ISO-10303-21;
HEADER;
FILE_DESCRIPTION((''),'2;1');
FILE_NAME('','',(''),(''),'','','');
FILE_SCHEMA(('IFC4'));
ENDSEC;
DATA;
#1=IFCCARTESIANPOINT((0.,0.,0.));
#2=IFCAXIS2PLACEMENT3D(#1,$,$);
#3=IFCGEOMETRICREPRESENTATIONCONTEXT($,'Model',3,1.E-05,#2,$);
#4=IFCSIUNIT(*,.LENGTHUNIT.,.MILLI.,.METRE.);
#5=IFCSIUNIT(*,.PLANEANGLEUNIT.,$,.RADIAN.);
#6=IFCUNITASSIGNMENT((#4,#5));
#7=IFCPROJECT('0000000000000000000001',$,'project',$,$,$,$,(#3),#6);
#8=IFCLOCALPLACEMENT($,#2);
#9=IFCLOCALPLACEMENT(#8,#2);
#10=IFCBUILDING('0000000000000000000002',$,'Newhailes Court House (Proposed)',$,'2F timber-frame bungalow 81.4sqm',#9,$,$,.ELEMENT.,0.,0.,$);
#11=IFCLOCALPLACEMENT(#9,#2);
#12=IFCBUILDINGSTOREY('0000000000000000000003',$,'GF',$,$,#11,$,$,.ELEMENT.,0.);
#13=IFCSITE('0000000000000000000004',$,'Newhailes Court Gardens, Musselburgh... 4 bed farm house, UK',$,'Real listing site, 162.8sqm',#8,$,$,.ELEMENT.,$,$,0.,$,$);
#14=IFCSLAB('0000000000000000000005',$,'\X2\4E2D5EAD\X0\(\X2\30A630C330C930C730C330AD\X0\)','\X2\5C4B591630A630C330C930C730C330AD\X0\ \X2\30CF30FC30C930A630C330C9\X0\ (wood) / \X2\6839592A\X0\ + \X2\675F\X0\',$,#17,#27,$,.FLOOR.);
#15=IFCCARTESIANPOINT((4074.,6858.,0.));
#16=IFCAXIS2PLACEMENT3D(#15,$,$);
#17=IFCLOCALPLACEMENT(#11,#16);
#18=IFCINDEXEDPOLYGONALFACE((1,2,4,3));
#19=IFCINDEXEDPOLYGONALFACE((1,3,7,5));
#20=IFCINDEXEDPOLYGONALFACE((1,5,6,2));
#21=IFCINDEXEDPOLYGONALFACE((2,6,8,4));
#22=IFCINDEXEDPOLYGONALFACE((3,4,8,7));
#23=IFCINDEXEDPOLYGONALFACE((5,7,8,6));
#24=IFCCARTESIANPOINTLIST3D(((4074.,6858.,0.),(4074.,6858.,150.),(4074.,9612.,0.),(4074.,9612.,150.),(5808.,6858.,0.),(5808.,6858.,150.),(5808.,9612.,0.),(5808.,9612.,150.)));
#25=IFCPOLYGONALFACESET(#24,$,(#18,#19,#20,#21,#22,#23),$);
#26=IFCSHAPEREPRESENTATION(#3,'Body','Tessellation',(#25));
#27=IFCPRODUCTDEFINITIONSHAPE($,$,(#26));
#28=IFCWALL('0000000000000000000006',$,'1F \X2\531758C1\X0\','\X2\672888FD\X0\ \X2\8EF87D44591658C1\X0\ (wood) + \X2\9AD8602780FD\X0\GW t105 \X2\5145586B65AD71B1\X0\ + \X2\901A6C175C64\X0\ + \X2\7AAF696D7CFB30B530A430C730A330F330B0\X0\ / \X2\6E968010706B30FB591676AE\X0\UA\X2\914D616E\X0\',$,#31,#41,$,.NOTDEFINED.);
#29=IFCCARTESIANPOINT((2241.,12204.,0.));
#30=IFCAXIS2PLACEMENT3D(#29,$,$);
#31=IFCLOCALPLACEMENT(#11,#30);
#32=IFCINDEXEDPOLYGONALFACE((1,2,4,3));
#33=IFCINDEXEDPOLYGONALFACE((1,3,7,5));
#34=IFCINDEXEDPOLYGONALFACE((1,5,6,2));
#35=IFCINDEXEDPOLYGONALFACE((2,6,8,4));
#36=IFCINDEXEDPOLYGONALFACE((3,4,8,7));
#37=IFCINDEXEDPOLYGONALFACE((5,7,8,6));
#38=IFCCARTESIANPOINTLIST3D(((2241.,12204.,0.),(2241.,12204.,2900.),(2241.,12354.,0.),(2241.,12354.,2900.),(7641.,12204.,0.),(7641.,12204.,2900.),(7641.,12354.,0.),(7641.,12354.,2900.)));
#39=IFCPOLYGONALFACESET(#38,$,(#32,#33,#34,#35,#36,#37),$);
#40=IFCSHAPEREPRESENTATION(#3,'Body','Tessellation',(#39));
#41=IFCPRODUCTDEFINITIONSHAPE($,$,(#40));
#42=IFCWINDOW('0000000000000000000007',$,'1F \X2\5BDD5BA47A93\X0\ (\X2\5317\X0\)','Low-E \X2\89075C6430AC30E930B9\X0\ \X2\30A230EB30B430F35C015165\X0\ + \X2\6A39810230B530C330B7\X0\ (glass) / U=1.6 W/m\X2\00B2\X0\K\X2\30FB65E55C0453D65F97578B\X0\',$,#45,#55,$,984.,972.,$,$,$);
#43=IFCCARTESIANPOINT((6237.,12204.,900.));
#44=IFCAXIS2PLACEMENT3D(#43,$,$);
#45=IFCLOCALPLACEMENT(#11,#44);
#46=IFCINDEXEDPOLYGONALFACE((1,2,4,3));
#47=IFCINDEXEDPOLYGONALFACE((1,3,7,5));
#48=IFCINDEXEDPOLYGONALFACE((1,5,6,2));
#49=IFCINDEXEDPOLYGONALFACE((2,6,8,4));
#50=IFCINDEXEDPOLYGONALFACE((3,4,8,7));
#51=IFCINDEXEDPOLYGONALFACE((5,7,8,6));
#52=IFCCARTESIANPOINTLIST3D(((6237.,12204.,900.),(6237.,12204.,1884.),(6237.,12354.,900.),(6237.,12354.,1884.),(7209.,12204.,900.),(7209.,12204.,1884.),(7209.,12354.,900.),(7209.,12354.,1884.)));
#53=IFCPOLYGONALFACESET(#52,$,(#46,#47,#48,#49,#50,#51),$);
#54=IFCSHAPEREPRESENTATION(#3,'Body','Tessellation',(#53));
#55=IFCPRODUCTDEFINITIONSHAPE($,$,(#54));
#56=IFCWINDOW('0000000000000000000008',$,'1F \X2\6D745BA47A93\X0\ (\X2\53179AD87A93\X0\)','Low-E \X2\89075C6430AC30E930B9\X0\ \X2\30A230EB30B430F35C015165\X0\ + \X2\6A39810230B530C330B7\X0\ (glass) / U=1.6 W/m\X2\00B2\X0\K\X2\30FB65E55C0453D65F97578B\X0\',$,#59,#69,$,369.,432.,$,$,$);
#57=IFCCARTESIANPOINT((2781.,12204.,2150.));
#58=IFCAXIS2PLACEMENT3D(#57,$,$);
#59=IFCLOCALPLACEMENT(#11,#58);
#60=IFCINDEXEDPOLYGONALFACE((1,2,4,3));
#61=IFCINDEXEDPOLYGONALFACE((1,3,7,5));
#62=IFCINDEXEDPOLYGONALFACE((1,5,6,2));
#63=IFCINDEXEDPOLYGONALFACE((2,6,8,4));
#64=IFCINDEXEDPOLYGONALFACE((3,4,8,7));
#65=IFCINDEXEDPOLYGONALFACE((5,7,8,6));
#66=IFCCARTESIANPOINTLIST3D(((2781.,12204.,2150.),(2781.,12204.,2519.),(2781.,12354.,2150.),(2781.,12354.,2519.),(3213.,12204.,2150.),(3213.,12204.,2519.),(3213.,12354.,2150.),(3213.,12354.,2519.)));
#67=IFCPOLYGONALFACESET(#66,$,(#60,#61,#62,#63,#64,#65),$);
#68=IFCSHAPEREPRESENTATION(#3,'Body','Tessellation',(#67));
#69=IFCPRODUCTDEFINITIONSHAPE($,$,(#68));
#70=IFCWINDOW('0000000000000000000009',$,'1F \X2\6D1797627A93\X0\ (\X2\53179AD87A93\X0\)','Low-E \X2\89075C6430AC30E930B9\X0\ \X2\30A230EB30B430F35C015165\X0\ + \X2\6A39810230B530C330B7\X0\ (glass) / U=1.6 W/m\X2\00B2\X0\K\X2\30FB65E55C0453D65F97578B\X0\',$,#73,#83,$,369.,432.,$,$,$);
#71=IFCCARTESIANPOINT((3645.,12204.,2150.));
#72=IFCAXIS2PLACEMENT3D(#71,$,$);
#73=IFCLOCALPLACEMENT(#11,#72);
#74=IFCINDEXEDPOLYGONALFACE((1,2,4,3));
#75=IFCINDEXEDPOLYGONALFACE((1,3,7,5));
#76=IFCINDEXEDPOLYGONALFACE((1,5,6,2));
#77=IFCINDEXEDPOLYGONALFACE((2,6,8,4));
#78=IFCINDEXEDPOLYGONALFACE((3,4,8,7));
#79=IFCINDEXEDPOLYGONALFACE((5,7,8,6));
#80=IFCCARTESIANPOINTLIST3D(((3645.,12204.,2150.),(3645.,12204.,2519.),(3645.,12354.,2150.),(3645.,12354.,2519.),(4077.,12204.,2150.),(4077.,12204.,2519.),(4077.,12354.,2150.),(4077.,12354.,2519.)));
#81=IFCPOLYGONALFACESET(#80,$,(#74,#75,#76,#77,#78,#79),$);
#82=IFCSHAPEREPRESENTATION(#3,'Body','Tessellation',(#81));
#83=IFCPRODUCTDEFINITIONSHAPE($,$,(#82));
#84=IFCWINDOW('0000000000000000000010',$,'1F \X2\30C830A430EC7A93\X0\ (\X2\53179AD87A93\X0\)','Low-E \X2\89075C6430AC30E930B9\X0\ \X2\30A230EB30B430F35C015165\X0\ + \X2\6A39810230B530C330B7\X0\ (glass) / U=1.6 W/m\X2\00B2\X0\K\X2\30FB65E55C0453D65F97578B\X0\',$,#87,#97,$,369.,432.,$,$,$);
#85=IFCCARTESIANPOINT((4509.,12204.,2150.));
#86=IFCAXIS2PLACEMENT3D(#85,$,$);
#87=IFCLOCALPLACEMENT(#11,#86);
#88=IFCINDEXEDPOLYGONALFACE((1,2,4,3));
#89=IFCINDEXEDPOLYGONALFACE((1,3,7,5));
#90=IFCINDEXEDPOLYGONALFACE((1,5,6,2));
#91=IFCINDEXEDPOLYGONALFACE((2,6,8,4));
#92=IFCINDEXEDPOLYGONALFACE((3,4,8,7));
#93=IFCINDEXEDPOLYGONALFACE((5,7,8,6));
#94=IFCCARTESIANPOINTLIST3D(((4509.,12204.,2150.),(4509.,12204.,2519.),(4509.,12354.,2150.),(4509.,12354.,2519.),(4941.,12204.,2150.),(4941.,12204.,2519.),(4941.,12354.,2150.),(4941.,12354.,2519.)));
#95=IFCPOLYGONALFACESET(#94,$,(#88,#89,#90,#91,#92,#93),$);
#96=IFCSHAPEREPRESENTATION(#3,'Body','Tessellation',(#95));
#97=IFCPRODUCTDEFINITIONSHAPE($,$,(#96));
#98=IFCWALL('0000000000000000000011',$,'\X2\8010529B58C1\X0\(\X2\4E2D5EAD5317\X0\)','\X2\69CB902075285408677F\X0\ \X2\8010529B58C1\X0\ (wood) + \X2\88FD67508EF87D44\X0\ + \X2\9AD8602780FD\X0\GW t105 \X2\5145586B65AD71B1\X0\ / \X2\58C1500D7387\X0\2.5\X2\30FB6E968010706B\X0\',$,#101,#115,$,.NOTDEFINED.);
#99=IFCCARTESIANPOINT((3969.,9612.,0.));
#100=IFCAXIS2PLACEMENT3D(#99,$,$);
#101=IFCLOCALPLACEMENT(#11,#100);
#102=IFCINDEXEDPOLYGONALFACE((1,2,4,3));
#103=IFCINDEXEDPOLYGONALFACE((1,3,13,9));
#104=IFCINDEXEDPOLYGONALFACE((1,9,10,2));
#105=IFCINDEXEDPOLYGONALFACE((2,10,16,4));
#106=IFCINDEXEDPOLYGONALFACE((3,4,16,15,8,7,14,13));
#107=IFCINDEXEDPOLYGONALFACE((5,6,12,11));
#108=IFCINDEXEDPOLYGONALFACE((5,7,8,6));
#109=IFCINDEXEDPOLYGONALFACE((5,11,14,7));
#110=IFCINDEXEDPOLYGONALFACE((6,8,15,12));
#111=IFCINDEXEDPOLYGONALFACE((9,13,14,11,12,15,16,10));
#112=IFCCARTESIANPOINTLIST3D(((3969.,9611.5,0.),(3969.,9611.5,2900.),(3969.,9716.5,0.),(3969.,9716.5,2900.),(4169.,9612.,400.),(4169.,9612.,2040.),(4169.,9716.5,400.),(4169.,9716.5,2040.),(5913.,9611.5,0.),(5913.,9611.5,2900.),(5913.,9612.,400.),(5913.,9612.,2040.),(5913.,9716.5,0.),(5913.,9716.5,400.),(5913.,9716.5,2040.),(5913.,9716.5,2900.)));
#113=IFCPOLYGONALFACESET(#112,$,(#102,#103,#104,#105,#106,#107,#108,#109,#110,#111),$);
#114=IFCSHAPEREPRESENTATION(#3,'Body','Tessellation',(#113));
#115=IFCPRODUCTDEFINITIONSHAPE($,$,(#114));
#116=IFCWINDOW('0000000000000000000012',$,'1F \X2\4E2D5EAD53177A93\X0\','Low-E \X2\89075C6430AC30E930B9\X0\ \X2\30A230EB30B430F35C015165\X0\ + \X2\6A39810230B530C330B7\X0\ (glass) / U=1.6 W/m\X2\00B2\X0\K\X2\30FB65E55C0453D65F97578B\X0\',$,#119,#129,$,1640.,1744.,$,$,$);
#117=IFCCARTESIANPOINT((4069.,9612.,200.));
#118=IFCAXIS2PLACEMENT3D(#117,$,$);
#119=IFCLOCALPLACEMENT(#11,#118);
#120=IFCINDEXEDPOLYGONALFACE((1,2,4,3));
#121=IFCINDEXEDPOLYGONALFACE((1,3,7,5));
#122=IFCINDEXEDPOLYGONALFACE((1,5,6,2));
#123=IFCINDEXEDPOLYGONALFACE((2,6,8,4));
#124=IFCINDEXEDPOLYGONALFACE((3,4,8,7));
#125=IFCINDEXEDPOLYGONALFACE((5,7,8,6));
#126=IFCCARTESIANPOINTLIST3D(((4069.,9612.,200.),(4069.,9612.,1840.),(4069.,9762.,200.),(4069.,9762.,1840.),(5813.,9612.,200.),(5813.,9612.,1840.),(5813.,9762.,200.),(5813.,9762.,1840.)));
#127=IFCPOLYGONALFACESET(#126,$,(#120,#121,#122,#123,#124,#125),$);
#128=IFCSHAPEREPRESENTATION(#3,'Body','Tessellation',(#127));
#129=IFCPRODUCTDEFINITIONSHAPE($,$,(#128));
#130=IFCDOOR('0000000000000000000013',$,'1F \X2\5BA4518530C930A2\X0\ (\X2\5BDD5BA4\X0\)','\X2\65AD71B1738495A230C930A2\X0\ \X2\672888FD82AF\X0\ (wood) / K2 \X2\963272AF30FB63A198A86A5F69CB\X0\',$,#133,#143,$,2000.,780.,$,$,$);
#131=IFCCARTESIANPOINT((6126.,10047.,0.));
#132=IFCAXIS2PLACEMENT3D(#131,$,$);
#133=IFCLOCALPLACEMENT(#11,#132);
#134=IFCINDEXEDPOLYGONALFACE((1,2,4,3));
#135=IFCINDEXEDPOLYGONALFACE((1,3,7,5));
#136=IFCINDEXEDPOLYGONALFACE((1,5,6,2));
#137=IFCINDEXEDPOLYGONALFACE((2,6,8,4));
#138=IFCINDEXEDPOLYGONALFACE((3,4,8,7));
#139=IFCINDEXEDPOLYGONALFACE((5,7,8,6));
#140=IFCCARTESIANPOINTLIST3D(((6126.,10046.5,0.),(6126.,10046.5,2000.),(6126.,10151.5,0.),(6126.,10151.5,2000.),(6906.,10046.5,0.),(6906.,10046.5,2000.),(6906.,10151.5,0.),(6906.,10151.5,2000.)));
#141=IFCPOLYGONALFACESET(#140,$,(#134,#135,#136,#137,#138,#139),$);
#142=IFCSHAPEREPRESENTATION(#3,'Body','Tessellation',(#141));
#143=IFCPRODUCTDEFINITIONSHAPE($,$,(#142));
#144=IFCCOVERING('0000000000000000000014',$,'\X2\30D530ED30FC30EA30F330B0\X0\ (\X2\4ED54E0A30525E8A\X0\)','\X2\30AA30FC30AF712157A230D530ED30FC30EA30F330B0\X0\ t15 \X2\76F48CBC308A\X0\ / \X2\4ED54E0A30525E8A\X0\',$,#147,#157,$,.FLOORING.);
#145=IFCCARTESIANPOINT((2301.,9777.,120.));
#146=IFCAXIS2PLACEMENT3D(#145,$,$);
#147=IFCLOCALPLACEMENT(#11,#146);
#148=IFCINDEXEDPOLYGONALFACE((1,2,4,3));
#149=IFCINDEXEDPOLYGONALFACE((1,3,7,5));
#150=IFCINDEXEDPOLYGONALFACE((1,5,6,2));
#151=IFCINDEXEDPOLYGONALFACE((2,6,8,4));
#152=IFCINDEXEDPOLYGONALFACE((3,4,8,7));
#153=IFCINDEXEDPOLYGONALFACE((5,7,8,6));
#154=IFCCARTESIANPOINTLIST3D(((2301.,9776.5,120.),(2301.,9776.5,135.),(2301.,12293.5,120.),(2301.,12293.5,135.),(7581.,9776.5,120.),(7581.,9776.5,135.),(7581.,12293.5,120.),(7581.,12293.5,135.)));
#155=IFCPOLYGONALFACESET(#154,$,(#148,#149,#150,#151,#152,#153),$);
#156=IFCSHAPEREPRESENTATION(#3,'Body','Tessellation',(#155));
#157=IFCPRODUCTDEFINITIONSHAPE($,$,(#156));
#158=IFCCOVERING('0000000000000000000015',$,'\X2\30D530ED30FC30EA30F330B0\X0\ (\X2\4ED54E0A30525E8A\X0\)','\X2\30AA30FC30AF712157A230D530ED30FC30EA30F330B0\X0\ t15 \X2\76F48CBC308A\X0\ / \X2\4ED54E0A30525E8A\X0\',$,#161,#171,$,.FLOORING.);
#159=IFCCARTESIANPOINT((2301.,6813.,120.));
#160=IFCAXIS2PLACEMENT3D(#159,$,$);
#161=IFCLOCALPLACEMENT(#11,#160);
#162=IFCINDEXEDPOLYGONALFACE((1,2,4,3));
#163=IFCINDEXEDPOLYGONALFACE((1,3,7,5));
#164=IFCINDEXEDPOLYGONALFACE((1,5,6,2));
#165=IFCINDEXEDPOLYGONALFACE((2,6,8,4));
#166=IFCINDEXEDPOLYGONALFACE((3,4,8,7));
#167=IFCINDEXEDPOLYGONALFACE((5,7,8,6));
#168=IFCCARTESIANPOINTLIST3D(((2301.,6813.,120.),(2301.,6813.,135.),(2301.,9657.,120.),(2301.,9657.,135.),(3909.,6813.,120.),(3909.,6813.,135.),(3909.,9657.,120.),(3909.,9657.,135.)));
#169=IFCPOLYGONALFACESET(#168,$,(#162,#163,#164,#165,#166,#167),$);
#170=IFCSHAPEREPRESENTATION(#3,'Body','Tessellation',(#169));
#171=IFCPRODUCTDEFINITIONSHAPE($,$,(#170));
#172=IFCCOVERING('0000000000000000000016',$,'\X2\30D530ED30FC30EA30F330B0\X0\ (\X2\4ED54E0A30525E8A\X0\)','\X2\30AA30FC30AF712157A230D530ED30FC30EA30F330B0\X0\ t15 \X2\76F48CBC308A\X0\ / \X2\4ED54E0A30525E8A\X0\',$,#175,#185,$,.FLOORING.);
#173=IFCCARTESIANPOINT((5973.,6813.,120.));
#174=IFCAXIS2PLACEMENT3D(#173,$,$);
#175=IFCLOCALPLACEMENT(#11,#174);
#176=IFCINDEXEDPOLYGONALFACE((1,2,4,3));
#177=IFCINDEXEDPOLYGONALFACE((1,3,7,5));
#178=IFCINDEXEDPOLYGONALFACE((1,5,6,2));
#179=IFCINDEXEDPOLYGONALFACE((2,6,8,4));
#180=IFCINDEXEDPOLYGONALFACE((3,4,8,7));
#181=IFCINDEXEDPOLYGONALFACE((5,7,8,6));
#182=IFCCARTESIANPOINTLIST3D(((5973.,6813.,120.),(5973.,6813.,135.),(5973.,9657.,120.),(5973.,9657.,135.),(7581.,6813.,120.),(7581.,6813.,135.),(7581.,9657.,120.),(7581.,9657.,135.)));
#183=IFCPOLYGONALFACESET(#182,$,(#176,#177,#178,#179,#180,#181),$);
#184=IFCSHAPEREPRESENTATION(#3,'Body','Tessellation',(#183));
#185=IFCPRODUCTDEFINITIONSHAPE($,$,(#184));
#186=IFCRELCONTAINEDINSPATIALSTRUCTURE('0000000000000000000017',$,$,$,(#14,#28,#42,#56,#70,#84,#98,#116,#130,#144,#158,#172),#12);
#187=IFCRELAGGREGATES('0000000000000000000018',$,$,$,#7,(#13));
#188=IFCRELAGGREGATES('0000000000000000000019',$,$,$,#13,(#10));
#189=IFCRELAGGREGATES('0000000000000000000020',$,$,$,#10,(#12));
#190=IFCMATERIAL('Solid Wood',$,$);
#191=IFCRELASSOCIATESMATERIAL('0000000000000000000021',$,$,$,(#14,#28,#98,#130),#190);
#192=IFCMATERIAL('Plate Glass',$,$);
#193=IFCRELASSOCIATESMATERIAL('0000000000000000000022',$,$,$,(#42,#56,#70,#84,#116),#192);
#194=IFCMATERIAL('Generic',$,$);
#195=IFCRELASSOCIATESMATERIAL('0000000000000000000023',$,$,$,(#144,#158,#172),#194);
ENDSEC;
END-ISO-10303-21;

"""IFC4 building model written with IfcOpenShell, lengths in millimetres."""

from ifc_helpers import new_model, si_unit, frame, frame_2d, origin, place, context, project, spatial, rectangle, extrude, material, element, fill, save


model = new_model("IFC4")

# Units and contexts
model_context = context("Model", 3, precision=1e-05, world=origin())
ifc_project = project(units=[si_unit("LENGTHUNIT", "METRE", prefix="MILLI"), si_unit("PLANEANGLEUNIT", "RADIAN")], contexts=[model_context])

# Site, building, storey
site_placement = place(None, origin())
site = spatial("IfcSite", under=ifc_project, at=site_placement, Name="Newhailes Court Gardens, Musselburgh... 4 bed farm house, UK", ObjectType="Real listing site, 162.8sqm", CompositionType="ELEMENT", RefElevation=0.0)
building_placement = place(site_placement, origin())
building = spatial("IfcBuilding", under=site, at=building_placement, Name="Newhailes Court House (Proposed)", ObjectType="2F timber-frame bungalow 81.4sqm", CompositionType="ELEMENT", ElevationOfRefHeight=0.0, ElevationOfTerrain=0.0)
storey_placement = place(building_placement, origin())
storey = spatial("IfcBuildingStorey", under=building, at=storey_placement, Name="GF", CompositionType="ELEMENT", Elevation=0.0)

# Slab
ifc_material_1 = material(Name="Solid Wood")
slab_1_placement = place(storey_placement, frame((4074.0, 6858.0, 0.0)))
element("IfcSlab", 1, at=slab_1_placement, inside=storey, material=ifc_material_1, Name="中庭(ウッドデッキ)", Description="屋外ウッドデッキ ハードウッド (wood) / 根太 + 束", PredefinedType="FLOOR", context=model_context, shape_type="SweptSolid", body=[
    extrude(rectangle(XDim=1734.0, YDim=2754.0, at=frame_2d((867.0, 1377.0))), frame((4074.0, 6858.0, 0.0)), (0.0, 0.0, 1.0), 150.0),
])

# Wall, openings, windows
wall_1_placement = place(storey_placement, frame((2241.0, 12204.0, 0.0)))
wall_1 = element("IfcWall", 2, at=wall_1_placement, inside=storey, material=ifc_material_1, Name="1F 北壁", Description="木製 軸組外壁 (wood) + 高性能GW t105 充填断熱 + 通気層 + 窯業系サイディング / 準耐火・外皮UA配慮", PredefinedType="NOTDEFINED", context=model_context, shape_type="SweptSolid", body=[
    extrude(rectangle(XDim=5400.0, YDim=150.0, at=frame_2d((2700.0, 75.0))), frame((2241.0, 12204.0, 0.0)), (0.0, 0.0, 1.0), 2900.0),
])
opening_1_placement = place(storey_placement, frame((6237.0, 12204.0, 900.0)))
opening_1 = element("IfcOpeningElement", 3, at=opening_1_placement, cuts=wall_1, PredefinedType="NOTDEFINED", context=model_context, shape_type="SweptSolid", body=[
    extrude(rectangle(XDim=972.0, YDim=150.0, at=frame_2d((486.0, 75.0))), frame((6237.0, 12204.0, 900.0)), (0.0, 0.0, 1.0), 984.0),
])
opening_2_placement = place(storey_placement, frame((2781.0, 12204.0, 2150.0)))
opening_2 = element("IfcOpeningElement", 4, at=opening_2_placement, cuts=wall_1, PredefinedType="NOTDEFINED", context=model_context, shape_type="SweptSolid", body=[
    extrude(rectangle(XDim=432.0, YDim=150.0, at=frame_2d((216.0, 75.0))), frame((2781.0, 12204.0, 2150.0)), (0.0, 0.0, 1.0), 369.0),
])
opening_3_placement = place(storey_placement, frame((3645.0, 12204.0, 2150.0)))
opening_3 = element("IfcOpeningElement", 5, at=opening_3_placement, cuts=wall_1, PredefinedType="NOTDEFINED", context=model_context, shape_type="SweptSolid", body=[
    extrude(rectangle(XDim=432.0, YDim=150.0, at=frame_2d((216.0, 75.0))), frame((3645.0, 12204.0, 2150.0)), (0.0, 0.0, 1.0), 369.0),
])
opening_4_placement = place(storey_placement, frame((4509.0, 12204.0, 2150.0)))
opening_4 = element("IfcOpeningElement", 6, at=opening_4_placement, cuts=wall_1, PredefinedType="NOTDEFINED", context=model_context, shape_type="SweptSolid", body=[
    extrude(rectangle(XDim=432.0, YDim=150.0, at=frame_2d((216.0, 75.0))), frame((4509.0, 12204.0, 2150.0)), (0.0, 0.0, 1.0), 369.0),
])
ifc_material_2 = material(Name="Plate Glass")
window_1_placement = place(storey_placement, frame((6237.0, 12204.0, 900.0)))
window_1 = element("IfcWindow", 7, at=window_1_placement, inside=storey, material=ifc_material_2, Name="1F 寝室窓 (北)", Description="Low-E 複層ガラス アルゴン封入 + 樹脂サッシ (glass) / U=1.6 W/m²K・日射取得型", OverallHeight=984.0, OverallWidth=972.0, context=model_context, shape_type="SweptSolid", body=[
    extrude(rectangle(XDim=972.0, YDim=150.0, at=frame_2d((486.0, 75.0))), frame((6237.0, 12204.0, 900.0)), (0.0, 0.0, 1.0), 984.0),
])
fill(opening_1, window_1)
window_2_placement = place(storey_placement, frame((2781.0, 12204.0, 2150.0)))
window_2 = element("IfcWindow", 8, at=window_2_placement, inside=storey, material=ifc_material_2, Name="1F 浴室窓 (北高窓)", Description="Low-E 複層ガラス アルゴン封入 + 樹脂サッシ (glass) / U=1.6 W/m²K・日射取得型", OverallHeight=369.0, OverallWidth=432.0, context=model_context, shape_type="SweptSolid", body=[
    extrude(rectangle(XDim=432.0, YDim=150.0, at=frame_2d((216.0, 75.0))), frame((2781.0, 12204.0, 2150.0)), (0.0, 0.0, 1.0), 369.0),
])
fill(opening_2, window_2)
window_3_placement = place(storey_placement, frame((3645.0, 12204.0, 2150.0)))
window_3 = element("IfcWindow", 9, at=window_3_placement, inside=storey, material=ifc_material_2, Name="1F 洗面窓 (北高窓)", Description="Low-E 複層ガラス アルゴン封入 + 樹脂サッシ (glass) / U=1.6 W/m²K・日射取得型", OverallHeight=369.0, OverallWidth=432.0, context=model_context, shape_type="SweptSolid", body=[
    extrude(rectangle(XDim=432.0, YDim=150.0, at=frame_2d((216.0, 75.0))), frame((3645.0, 12204.0, 2150.0)), (0.0, 0.0, 1.0), 369.0),
])
fill(opening_3, window_3)
window_4_placement = place(storey_placement, frame((4509.0, 12204.0, 2150.0)))
window_4 = element("IfcWindow", 10, at=window_4_placement, inside=storey, material=ifc_material_2, Name="1F トイレ窓 (北高窓)", Description="Low-E 複層ガラス アルゴン封入 + 樹脂サッシ (glass) / U=1.6 W/m²K・日射取得型", OverallHeight=369.0, OverallWidth=432.0, context=model_context, shape_type="SweptSolid", body=[
    extrude(rectangle(XDim=432.0, YDim=150.0, at=frame_2d((216.0, 75.0))), frame((4509.0, 12204.0, 2150.0)), (0.0, 0.0, 1.0), 369.0),
])
fill(opening_4, window_4)

# Wall, opening, window
wall_2_placement = place(storey_placement, frame((3969.0, 9612.0, 0.0)))
wall_2 = element("IfcWall", 11, at=wall_2_placement, inside=storey, material=ifc_material_1, Name="耐力壁(中庭北)", Description="構造用合板 耐力壁 (wood) + 製材軸組 + 高性能GW t105 充填断熱 / 壁倍率2.5・準耐火", PredefinedType="NOTDEFINED", context=model_context, shape_type="SweptSolid", body=[
    extrude(rectangle(XDim=1944.0, YDim=105.0, at=frame_2d((972.0, 52.0))), frame((3969.0, 9612.0, 0.0)), (0.0, 0.0, 1.0), 2900.0),
])
opening_5_placement = place(storey_placement, frame((4069.0, 9612.0, 200.0)))
opening_5 = element("IfcOpeningElement", 12, at=opening_5_placement, cuts=wall_2, PredefinedType="NOTDEFINED", context=model_context, shape_type="SweptSolid", body=[
    extrude(rectangle(XDim=1744.0, YDim=150.0, at=frame_2d((872.0, 75.0))), frame((4069.0, 9612.0, 200.0)), (0.0, 0.0, 1.0), 1640.0),
])
window_5_placement = place(storey_placement, frame((4069.0, 9612.0, 200.0)))
window_5 = element("IfcWindow", 13, at=window_5_placement, inside=storey, material=ifc_material_2, Name="1F 中庭北窓", Description="Low-E 複層ガラス アルゴン封入 + 樹脂サッシ (glass) / U=1.6 W/m²K・日射取得型", OverallHeight=1640.0, OverallWidth=1744.0, context=model_context, shape_type="SweptSolid", body=[
    extrude(rectangle(XDim=1744.0, YDim=150.0, at=frame_2d((872.0, 75.0))), frame((4069.0, 9612.0, 200.0)), (0.0, 0.0, 1.0), 1640.0),
])
fill(opening_5, window_5)

# Door
door_1_placement = place(storey_placement, frame((6126.0, 10047.0, 0.0)))
element("IfcDoor", 14, at=door_1_placement, inside=storey, material=ifc_material_1, Name="1F 室内ドア (寝室)", Description="断熱玄関ドア 木製芯 (wood) / K2 防犯・採風機構", OverallHeight=2000.0, OverallWidth=780.0, context=model_context, shape_type="SweptSolid", body=[
    extrude(rectangle(XDim=780.0, YDim=105.0, at=frame_2d((390.0, 52.0))), frame((6126.0, 10047.0, 0.0)), (0.0, 0.0, 1.0), 2000.0),
])

# Coverings
ifc_material_3 = material(Name="Generic")
covering_1_placement = place(storey_placement, frame((2301.0, 9777.0, 120.0)))
element("IfcCovering", 15, at=covering_1_placement, inside=storey, material=ifc_material_3, Name="フローリング (仕上げ床)", Description="オーク無垢フローリング t15 直貼り / 仕上げ床", PredefinedType="FLOORING", context=model_context, shape_type="SweptSolid", body=[
    extrude(rectangle(XDim=5280.0, YDim=2517.0, at=frame_2d((2640.0, 1258.0))), frame((2301.0, 9777.0, 120.0)), (0.0, 0.0, 1.0), 15.0),
])
covering_2_placement = place(storey_placement, frame((2301.0, 6813.0, 120.0)))
element("IfcCovering", 16, at=covering_2_placement, inside=storey, material=ifc_material_3, Name="フローリング (仕上げ床)", Description="オーク無垢フローリング t15 直貼り / 仕上げ床", PredefinedType="FLOORING", context=model_context, shape_type="SweptSolid", body=[
    extrude(rectangle(XDim=1608.0, YDim=2844.0, at=frame_2d((804.0, 1422.0))), frame((2301.0, 6813.0, 120.0)), (0.0, 0.0, 1.0), 15.0),
])
covering_3_placement = place(storey_placement, frame((5973.0, 6813.0, 120.0)))
element("IfcCovering", 17, at=covering_3_placement, inside=storey, material=ifc_material_3, Name="フローリング (仕上げ床)", Description="オーク無垢フローリング t15 直貼り / 仕上げ床", PredefinedType="FLOORING", context=model_context, shape_type="SweptSolid", body=[
    extrude(rectangle(XDim=1608.0, YDim=2844.0, at=frame_2d((804.0, 1422.0))), frame((5973.0, 6813.0, 120.0)), (0.0, 0.0, 1.0), 15.0),
])

save(model, "model.ifc")
